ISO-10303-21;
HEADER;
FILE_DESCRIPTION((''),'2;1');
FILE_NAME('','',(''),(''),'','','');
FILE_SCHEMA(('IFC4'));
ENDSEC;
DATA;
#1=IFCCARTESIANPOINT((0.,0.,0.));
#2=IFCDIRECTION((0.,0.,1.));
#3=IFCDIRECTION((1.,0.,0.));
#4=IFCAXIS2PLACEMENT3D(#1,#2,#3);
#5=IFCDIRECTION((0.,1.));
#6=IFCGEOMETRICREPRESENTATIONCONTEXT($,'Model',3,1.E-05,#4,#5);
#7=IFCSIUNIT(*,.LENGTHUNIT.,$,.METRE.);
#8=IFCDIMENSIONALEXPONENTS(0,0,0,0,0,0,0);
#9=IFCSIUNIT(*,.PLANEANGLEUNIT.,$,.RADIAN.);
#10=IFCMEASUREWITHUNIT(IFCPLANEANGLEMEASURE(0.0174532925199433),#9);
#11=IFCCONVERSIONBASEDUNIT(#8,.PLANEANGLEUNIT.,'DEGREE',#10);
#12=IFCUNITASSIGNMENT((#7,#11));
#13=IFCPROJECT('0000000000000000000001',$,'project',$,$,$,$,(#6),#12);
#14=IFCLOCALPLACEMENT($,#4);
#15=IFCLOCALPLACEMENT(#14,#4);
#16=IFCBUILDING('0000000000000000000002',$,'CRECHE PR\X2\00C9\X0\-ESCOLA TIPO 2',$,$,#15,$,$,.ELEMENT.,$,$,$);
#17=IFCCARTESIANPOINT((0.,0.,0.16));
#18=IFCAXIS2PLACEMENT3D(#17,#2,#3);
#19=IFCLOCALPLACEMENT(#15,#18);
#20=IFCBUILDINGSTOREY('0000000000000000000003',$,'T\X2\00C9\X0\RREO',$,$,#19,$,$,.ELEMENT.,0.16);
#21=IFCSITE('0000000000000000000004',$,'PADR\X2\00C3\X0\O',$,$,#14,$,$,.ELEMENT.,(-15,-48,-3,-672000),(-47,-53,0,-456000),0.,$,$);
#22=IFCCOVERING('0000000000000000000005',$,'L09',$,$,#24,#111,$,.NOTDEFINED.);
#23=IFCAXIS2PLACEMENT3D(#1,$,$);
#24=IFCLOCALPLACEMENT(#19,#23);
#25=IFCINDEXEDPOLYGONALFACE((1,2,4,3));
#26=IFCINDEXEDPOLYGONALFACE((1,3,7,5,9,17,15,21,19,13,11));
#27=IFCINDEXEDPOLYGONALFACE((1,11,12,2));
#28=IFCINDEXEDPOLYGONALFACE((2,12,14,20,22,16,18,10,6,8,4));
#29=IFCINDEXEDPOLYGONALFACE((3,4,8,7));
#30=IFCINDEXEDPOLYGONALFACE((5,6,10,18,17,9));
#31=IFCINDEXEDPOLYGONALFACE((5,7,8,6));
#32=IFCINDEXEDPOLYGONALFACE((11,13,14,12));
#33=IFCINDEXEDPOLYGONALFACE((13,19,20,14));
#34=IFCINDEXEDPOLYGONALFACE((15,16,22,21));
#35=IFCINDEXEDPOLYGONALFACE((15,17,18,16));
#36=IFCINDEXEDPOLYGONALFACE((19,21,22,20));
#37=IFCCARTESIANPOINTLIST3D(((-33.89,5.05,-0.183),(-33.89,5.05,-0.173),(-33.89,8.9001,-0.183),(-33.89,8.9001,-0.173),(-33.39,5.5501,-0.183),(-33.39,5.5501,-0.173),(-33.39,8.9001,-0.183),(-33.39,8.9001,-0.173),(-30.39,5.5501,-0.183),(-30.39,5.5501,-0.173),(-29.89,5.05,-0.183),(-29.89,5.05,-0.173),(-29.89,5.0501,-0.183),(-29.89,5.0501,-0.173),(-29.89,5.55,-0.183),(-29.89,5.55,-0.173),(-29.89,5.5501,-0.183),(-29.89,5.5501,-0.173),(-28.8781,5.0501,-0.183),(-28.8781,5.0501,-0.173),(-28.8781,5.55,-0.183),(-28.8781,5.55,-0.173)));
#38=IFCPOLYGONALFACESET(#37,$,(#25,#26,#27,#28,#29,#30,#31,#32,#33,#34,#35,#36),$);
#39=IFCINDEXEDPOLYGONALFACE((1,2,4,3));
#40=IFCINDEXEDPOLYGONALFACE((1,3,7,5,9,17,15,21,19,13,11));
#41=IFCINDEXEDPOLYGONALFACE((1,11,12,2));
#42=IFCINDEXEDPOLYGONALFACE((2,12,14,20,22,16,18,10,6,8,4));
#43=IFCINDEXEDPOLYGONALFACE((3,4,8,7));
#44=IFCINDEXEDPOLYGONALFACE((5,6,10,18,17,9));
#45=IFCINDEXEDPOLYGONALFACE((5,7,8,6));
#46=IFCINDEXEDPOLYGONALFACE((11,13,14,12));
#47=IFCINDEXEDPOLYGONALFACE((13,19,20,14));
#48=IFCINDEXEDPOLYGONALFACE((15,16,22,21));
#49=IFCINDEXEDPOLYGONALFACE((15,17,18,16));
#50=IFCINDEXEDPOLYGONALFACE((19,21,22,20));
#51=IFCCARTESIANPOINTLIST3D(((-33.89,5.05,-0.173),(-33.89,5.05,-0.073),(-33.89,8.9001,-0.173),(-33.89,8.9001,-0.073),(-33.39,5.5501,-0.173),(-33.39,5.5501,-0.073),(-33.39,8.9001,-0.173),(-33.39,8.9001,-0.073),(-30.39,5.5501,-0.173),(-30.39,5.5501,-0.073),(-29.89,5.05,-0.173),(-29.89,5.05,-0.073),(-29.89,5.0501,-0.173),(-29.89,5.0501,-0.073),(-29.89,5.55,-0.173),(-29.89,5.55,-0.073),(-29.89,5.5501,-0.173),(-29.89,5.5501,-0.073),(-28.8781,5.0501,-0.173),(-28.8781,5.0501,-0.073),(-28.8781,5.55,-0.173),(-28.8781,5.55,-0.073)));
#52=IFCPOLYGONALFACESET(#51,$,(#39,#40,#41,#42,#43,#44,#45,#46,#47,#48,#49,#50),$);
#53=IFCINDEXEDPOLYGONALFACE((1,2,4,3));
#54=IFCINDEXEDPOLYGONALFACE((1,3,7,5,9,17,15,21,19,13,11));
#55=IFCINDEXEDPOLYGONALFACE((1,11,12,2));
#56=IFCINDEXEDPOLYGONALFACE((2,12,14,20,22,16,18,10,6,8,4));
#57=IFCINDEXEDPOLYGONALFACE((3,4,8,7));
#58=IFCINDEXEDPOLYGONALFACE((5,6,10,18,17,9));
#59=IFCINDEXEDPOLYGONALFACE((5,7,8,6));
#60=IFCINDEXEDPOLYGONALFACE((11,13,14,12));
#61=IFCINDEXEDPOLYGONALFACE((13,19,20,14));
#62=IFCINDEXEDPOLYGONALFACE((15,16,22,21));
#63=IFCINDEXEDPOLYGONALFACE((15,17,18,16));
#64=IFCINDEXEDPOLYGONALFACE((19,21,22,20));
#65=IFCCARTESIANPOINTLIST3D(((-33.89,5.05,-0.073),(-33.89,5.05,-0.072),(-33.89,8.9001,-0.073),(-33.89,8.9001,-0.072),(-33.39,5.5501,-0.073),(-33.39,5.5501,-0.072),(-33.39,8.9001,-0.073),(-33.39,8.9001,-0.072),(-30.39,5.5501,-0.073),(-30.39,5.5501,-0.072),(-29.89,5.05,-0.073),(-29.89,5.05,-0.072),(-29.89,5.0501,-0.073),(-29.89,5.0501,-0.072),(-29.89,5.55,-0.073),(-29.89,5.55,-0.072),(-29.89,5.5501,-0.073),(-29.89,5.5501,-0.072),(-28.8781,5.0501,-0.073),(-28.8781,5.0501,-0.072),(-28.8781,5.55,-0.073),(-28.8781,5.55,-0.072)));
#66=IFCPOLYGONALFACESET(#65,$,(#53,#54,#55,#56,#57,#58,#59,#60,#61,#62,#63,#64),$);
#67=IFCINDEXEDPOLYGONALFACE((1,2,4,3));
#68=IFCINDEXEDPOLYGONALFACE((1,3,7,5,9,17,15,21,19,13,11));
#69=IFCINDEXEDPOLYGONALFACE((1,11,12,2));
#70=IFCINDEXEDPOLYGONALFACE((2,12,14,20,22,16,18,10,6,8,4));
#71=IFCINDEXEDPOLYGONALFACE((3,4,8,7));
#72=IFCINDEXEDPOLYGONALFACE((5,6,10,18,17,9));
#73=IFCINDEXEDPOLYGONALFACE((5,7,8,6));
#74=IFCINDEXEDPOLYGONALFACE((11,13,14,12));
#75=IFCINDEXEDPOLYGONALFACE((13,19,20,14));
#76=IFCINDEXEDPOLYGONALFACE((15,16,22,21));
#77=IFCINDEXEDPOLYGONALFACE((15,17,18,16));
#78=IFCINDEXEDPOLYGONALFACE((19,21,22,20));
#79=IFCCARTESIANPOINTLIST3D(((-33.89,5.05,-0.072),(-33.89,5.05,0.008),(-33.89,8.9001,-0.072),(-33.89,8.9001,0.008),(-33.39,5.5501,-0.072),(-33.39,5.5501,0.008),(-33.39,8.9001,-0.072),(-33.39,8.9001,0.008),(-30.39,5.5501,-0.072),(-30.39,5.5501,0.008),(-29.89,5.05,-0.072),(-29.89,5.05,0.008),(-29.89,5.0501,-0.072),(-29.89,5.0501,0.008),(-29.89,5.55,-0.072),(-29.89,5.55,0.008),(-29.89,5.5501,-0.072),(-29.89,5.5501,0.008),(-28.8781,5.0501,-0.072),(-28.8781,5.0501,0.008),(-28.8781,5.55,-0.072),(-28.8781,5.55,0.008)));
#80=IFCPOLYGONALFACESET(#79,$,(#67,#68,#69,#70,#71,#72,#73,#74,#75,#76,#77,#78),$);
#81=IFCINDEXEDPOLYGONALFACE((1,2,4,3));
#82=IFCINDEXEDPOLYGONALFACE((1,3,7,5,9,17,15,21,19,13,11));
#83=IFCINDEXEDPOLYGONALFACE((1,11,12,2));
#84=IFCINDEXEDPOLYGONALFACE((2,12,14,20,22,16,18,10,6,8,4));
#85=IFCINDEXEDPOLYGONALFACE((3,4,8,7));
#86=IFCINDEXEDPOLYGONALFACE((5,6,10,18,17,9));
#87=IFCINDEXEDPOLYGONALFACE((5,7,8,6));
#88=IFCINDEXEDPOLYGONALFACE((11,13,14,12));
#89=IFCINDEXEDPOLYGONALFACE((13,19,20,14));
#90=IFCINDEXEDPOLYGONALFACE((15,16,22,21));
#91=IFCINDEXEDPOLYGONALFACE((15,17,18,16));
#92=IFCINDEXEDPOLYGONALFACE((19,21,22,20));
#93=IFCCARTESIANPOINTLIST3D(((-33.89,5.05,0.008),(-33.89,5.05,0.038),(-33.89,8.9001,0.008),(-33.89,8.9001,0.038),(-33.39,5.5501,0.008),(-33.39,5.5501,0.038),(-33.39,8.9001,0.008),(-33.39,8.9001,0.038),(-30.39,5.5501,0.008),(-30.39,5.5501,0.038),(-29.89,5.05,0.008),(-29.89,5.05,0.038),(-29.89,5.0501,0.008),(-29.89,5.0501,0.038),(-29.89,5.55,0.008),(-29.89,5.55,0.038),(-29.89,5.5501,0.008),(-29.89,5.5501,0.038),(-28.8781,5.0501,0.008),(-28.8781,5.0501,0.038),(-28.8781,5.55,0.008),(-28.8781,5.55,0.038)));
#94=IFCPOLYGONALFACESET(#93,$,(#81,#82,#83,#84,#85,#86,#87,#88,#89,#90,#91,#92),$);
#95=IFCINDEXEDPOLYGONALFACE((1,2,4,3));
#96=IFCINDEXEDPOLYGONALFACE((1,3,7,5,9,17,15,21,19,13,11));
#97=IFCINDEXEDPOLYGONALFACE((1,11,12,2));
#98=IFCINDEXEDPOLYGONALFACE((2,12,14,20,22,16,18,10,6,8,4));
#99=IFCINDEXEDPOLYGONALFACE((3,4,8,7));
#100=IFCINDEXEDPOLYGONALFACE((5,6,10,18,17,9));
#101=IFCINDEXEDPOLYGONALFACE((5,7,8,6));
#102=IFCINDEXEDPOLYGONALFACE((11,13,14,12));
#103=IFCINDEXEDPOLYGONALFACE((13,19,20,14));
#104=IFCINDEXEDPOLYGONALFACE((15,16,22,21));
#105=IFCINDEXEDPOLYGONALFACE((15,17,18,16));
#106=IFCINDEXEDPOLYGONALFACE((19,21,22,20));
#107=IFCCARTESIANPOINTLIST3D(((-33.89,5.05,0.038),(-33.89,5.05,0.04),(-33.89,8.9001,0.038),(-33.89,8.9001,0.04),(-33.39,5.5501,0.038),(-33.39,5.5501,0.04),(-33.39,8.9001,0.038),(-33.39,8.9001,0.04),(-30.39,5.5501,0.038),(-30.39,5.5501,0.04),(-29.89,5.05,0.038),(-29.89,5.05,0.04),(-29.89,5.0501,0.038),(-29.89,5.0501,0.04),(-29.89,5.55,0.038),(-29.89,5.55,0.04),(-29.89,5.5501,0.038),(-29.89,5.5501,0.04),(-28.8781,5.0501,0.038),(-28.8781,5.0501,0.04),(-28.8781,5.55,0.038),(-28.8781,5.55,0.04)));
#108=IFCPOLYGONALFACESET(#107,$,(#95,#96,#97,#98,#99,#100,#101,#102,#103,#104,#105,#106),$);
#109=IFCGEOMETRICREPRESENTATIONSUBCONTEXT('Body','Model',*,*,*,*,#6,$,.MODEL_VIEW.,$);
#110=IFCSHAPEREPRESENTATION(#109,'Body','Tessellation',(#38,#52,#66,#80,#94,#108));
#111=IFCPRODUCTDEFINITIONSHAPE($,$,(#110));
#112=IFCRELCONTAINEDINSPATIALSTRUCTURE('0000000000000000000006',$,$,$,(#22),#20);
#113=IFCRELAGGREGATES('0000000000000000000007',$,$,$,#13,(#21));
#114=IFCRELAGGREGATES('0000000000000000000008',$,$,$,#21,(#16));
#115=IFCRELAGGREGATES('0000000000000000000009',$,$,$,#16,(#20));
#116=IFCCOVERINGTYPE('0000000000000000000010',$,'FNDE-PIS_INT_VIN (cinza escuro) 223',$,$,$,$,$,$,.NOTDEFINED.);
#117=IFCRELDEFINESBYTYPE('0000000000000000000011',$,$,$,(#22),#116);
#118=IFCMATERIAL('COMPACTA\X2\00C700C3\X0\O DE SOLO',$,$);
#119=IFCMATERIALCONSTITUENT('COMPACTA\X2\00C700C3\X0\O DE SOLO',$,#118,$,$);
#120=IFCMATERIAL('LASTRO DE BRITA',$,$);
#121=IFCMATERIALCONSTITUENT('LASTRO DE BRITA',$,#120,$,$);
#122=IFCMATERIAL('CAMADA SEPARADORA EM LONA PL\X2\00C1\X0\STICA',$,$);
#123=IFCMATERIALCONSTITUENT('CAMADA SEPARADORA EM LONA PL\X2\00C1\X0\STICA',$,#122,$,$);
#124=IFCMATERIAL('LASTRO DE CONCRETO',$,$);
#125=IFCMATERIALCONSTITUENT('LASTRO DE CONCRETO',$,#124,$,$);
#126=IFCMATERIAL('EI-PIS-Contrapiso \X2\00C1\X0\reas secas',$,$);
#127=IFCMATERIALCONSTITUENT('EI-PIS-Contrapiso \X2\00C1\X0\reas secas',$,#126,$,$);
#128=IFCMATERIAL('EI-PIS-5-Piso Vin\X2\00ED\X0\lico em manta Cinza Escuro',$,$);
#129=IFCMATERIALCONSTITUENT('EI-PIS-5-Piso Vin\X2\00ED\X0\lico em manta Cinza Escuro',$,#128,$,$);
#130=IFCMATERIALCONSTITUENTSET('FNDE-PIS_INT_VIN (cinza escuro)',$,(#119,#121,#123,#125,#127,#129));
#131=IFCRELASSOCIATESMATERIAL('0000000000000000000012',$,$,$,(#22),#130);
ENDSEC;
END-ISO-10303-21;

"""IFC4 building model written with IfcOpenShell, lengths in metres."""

from ifc_helpers import new_model, entity, si_unit, converted_unit, direction, frame, origin_with_axes, place, context, subcontext, project, spatial, line, indexed_curve, outline, extrude, material, constituent, constituent_set, type_object, element, save


model = new_model("IFC4")

# Units and contexts
model_context = context("Model", 3, precision=1e-05, world=origin_with_axes(), true_north=direction((0.0, 1.0)))
body_context = subcontext(model_context, "Body", "Model", "MODEL_VIEW")
ifc_project = project(units=[si_unit("LENGTHUNIT", "METRE"), converted_unit("PLANEANGLEUNIT", "DEGREE", entity("IfcPlaneAngleMeasure", 0.0174532925199433), si_unit("PLANEANGLEUNIT", "RADIAN"), dimensions=[0, 0, 0, 0, 0, 0, 0])], contexts=[model_context])

# Site, building, storey
site_placement = place(None, origin_with_axes())
site = spatial("IfcSite", under=ifc_project, at=site_placement, Name="PADRÃO", CompositionType="ELEMENT", RefLatitude=(-15, -48, -3, -672000), RefLongitude=(-47, -53, 0, -456000), RefElevation=0.0)
building_placement = place(site_placement, origin_with_axes())
building = spatial("IfcBuilding", under=site, at=building_placement, Name="CRECHE PRÉ-ESCOLA TIPO 2", CompositionType="ELEMENT")
storey_placement = place(building_placement, frame((0.0, 0.0, 0.16), z_axis=(0.0, 0.0, 1.0), x_axis=(1.0, 0.0, 0.0)))
storey = spatial("IfcBuildingStorey", under=building, at=storey_placement, Name="TÉRREO", CompositionType="ELEMENT", Elevation=0.16)

# Covering
ifc_material_1 = material(Name="COMPACTAÇÃO DE SOLO")
ifc_material_2 = material(Name="LASTRO DE BRITA")
ifc_constituent_1 = constituent(ifc_material_1, Name="COMPACTAÇÃO DE SOLO")
ifc_constituent_2 = constituent(ifc_material_2, Name="LASTRO DE BRITA")
ifc_material_3 = material(Name="CAMADA SEPARADORA EM LONA PLÁSTICA")
ifc_constituent_3 = constituent(ifc_material_3, Name="CAMADA SEPARADORA EM LONA PLÁSTICA")
ifc_material_4 = material(Name="LASTRO DE CONCRETO")
ifc_constituent_4 = constituent(ifc_material_4, Name="LASTRO DE CONCRETO")
ifc_material_5 = material(Name="EI-PIS-Contrapiso Áreas secas")
ifc_constituent_5 = constituent(ifc_material_5, Name="EI-PIS-Contrapiso Áreas secas")
ifc_material_6 = material(Name="EI-PIS-5-Piso Vinílico em manta Cinza Escuro")
ifc_constituent_6 = constituent(ifc_material_6, Name="EI-PIS-5-Piso Vinílico em manta Cinza Escuro")
ifc_constituent_set_1 = constituent_set(constituents=[ifc_constituent_1, ifc_constituent_2, ifc_constituent_3, ifc_constituent_4, ifc_constituent_5, ifc_constituent_6], Name="FNDE-PIS_INT_VIN (cinza escuro)")
covering_type_1 = type_object("IfcCoveringType", Name="FNDE-PIS_INT_VIN (cinza escuro) 223", PredefinedType="NOTDEFINED")
covering_1_placement = place(storey_placement, frame((-33.89, 5.05, 0.04), z_axis=(0.0, 0.0, 1.0), x_axis=(1.0, 0.0, 0.0)))
element("IfcCovering", 1, at=covering_1_placement, inside=storey, type_object=covering_type_1, material=ifc_constituent_set_1, Name="L09", PredefinedType="NOTDEFINED", context=body_context, shape_type="SweptSolid", body=[
    extrude(outline(indexed_curve([(0.0, 0.0), (4.0, 0.0), (4.0, 0.0001), (5.012, 0.0001), (5.012, 0.5), (4.0, 0.5), (4.0, 0.5001), (3.5, 0.5001), (0.5, 0.5001), (0.5, 3.8501), (0.0, 3.8501)], segments=[line(1, 2, 3, 4, 5, 6, 7, 8, 9, 10, 11, 1)])), frame((0.0, 0.0, -0.223), z_axis=(0.0, 0.0, 1.0), x_axis=(1.0, 0.0, 0.0)), (0.0, 0.0, 1.0), 0.01),
    extrude(outline(indexed_curve([(0.0, 0.0), (4.0, 0.0), (4.0, 0.0001), (5.012, 0.0001), (5.012, 0.5), (4.0, 0.5), (4.0, 0.5001), (3.5, 0.5001), (0.5, 0.5001), (0.5, 3.8501), (0.0, 3.8501)], segments=[line(1, 2, 3, 4, 5, 6, 7, 8, 9, 10, 11, 1)])), frame((0.0, 0.0, -0.213), z_axis=(0.0, 0.0, 1.0), x_axis=(1.0, 0.0, 0.0)), (0.0, 0.0, 1.0), 0.1),
    extrude(outline(indexed_curve([(0.0, 0.0), (4.0, 0.0), (4.0, 0.0001), (5.012, 0.0001), (5.012, 0.5), (4.0, 0.5), (4.0, 0.5001), (3.5, 0.5001), (0.5, 0.5001), (0.5, 3.8501), (0.0, 3.8501)], segments=[line(1, 2, 3, 4, 5, 6, 7, 8, 9, 10, 11, 1)])), frame((0.0, 0.0, -0.113), z_axis=(0.0, 0.0, 1.0), x_axis=(1.0, 0.0, 0.0)), (0.0, 0.0, 1.0), 0.001),
    extrude(outline(indexed_curve([(0.0, 0.0), (4.0, 0.0), (4.0, 0.0001), (5.012, 0.0001), (5.012, 0.5), (4.0, 0.5), (4.0, 0.5001), (3.5, 0.5001), (0.5, 0.5001), (0.5, 3.8501), (0.0, 3.8501)], segments=[line(1, 2, 3, 4, 5, 6, 7, 8, 9, 10, 11, 1)])), frame((0.0, 0.0, -0.112), z_axis=(0.0, 0.0, 1.0), x_axis=(1.0, 0.0, 0.0)), (0.0, 0.0, 1.0), 0.08),
    extrude(outline(indexed_curve([(0.0, 0.0), (4.0, 0.0), (4.0, 0.0001), (5.012, 0.0001), (5.012, 0.5), (4.0, 0.5), (4.0, 0.5001), (3.5, 0.5001), (0.5, 0.5001), (0.5, 3.8501), (0.0, 3.8501)], segments=[line(1, 2, 3, 4, 5, 6, 7, 8, 9, 10, 11, 1)])), frame((0.0, 0.0, -0.032), z_axis=(0.0, 0.0, 1.0), x_axis=(1.0, 0.0, 0.0)), (0.0, 0.0, 1.0), 0.03),
    extrude(outline(indexed_curve([(0.0, 0.0), (4.0, 0.0), (4.0, 0.0001), (5.012, 0.0001), (5.012, 0.5), (4.0, 0.5), (4.0, 0.5001), (3.5, 0.5001), (0.5, 0.5001), (0.5, 3.8501), (0.0, 3.8501)], segments=[line(1, 2, 3, 4, 5, 6, 7, 8, 9, 10, 11, 1)])), frame((0.0, 0.0, -0.002), z_axis=(0.0, 0.0, 1.0), x_axis=(1.0, 0.0, 0.0)), (0.0, 0.0, 1.0), 0.002),
])

save(model, "model.ifc")
